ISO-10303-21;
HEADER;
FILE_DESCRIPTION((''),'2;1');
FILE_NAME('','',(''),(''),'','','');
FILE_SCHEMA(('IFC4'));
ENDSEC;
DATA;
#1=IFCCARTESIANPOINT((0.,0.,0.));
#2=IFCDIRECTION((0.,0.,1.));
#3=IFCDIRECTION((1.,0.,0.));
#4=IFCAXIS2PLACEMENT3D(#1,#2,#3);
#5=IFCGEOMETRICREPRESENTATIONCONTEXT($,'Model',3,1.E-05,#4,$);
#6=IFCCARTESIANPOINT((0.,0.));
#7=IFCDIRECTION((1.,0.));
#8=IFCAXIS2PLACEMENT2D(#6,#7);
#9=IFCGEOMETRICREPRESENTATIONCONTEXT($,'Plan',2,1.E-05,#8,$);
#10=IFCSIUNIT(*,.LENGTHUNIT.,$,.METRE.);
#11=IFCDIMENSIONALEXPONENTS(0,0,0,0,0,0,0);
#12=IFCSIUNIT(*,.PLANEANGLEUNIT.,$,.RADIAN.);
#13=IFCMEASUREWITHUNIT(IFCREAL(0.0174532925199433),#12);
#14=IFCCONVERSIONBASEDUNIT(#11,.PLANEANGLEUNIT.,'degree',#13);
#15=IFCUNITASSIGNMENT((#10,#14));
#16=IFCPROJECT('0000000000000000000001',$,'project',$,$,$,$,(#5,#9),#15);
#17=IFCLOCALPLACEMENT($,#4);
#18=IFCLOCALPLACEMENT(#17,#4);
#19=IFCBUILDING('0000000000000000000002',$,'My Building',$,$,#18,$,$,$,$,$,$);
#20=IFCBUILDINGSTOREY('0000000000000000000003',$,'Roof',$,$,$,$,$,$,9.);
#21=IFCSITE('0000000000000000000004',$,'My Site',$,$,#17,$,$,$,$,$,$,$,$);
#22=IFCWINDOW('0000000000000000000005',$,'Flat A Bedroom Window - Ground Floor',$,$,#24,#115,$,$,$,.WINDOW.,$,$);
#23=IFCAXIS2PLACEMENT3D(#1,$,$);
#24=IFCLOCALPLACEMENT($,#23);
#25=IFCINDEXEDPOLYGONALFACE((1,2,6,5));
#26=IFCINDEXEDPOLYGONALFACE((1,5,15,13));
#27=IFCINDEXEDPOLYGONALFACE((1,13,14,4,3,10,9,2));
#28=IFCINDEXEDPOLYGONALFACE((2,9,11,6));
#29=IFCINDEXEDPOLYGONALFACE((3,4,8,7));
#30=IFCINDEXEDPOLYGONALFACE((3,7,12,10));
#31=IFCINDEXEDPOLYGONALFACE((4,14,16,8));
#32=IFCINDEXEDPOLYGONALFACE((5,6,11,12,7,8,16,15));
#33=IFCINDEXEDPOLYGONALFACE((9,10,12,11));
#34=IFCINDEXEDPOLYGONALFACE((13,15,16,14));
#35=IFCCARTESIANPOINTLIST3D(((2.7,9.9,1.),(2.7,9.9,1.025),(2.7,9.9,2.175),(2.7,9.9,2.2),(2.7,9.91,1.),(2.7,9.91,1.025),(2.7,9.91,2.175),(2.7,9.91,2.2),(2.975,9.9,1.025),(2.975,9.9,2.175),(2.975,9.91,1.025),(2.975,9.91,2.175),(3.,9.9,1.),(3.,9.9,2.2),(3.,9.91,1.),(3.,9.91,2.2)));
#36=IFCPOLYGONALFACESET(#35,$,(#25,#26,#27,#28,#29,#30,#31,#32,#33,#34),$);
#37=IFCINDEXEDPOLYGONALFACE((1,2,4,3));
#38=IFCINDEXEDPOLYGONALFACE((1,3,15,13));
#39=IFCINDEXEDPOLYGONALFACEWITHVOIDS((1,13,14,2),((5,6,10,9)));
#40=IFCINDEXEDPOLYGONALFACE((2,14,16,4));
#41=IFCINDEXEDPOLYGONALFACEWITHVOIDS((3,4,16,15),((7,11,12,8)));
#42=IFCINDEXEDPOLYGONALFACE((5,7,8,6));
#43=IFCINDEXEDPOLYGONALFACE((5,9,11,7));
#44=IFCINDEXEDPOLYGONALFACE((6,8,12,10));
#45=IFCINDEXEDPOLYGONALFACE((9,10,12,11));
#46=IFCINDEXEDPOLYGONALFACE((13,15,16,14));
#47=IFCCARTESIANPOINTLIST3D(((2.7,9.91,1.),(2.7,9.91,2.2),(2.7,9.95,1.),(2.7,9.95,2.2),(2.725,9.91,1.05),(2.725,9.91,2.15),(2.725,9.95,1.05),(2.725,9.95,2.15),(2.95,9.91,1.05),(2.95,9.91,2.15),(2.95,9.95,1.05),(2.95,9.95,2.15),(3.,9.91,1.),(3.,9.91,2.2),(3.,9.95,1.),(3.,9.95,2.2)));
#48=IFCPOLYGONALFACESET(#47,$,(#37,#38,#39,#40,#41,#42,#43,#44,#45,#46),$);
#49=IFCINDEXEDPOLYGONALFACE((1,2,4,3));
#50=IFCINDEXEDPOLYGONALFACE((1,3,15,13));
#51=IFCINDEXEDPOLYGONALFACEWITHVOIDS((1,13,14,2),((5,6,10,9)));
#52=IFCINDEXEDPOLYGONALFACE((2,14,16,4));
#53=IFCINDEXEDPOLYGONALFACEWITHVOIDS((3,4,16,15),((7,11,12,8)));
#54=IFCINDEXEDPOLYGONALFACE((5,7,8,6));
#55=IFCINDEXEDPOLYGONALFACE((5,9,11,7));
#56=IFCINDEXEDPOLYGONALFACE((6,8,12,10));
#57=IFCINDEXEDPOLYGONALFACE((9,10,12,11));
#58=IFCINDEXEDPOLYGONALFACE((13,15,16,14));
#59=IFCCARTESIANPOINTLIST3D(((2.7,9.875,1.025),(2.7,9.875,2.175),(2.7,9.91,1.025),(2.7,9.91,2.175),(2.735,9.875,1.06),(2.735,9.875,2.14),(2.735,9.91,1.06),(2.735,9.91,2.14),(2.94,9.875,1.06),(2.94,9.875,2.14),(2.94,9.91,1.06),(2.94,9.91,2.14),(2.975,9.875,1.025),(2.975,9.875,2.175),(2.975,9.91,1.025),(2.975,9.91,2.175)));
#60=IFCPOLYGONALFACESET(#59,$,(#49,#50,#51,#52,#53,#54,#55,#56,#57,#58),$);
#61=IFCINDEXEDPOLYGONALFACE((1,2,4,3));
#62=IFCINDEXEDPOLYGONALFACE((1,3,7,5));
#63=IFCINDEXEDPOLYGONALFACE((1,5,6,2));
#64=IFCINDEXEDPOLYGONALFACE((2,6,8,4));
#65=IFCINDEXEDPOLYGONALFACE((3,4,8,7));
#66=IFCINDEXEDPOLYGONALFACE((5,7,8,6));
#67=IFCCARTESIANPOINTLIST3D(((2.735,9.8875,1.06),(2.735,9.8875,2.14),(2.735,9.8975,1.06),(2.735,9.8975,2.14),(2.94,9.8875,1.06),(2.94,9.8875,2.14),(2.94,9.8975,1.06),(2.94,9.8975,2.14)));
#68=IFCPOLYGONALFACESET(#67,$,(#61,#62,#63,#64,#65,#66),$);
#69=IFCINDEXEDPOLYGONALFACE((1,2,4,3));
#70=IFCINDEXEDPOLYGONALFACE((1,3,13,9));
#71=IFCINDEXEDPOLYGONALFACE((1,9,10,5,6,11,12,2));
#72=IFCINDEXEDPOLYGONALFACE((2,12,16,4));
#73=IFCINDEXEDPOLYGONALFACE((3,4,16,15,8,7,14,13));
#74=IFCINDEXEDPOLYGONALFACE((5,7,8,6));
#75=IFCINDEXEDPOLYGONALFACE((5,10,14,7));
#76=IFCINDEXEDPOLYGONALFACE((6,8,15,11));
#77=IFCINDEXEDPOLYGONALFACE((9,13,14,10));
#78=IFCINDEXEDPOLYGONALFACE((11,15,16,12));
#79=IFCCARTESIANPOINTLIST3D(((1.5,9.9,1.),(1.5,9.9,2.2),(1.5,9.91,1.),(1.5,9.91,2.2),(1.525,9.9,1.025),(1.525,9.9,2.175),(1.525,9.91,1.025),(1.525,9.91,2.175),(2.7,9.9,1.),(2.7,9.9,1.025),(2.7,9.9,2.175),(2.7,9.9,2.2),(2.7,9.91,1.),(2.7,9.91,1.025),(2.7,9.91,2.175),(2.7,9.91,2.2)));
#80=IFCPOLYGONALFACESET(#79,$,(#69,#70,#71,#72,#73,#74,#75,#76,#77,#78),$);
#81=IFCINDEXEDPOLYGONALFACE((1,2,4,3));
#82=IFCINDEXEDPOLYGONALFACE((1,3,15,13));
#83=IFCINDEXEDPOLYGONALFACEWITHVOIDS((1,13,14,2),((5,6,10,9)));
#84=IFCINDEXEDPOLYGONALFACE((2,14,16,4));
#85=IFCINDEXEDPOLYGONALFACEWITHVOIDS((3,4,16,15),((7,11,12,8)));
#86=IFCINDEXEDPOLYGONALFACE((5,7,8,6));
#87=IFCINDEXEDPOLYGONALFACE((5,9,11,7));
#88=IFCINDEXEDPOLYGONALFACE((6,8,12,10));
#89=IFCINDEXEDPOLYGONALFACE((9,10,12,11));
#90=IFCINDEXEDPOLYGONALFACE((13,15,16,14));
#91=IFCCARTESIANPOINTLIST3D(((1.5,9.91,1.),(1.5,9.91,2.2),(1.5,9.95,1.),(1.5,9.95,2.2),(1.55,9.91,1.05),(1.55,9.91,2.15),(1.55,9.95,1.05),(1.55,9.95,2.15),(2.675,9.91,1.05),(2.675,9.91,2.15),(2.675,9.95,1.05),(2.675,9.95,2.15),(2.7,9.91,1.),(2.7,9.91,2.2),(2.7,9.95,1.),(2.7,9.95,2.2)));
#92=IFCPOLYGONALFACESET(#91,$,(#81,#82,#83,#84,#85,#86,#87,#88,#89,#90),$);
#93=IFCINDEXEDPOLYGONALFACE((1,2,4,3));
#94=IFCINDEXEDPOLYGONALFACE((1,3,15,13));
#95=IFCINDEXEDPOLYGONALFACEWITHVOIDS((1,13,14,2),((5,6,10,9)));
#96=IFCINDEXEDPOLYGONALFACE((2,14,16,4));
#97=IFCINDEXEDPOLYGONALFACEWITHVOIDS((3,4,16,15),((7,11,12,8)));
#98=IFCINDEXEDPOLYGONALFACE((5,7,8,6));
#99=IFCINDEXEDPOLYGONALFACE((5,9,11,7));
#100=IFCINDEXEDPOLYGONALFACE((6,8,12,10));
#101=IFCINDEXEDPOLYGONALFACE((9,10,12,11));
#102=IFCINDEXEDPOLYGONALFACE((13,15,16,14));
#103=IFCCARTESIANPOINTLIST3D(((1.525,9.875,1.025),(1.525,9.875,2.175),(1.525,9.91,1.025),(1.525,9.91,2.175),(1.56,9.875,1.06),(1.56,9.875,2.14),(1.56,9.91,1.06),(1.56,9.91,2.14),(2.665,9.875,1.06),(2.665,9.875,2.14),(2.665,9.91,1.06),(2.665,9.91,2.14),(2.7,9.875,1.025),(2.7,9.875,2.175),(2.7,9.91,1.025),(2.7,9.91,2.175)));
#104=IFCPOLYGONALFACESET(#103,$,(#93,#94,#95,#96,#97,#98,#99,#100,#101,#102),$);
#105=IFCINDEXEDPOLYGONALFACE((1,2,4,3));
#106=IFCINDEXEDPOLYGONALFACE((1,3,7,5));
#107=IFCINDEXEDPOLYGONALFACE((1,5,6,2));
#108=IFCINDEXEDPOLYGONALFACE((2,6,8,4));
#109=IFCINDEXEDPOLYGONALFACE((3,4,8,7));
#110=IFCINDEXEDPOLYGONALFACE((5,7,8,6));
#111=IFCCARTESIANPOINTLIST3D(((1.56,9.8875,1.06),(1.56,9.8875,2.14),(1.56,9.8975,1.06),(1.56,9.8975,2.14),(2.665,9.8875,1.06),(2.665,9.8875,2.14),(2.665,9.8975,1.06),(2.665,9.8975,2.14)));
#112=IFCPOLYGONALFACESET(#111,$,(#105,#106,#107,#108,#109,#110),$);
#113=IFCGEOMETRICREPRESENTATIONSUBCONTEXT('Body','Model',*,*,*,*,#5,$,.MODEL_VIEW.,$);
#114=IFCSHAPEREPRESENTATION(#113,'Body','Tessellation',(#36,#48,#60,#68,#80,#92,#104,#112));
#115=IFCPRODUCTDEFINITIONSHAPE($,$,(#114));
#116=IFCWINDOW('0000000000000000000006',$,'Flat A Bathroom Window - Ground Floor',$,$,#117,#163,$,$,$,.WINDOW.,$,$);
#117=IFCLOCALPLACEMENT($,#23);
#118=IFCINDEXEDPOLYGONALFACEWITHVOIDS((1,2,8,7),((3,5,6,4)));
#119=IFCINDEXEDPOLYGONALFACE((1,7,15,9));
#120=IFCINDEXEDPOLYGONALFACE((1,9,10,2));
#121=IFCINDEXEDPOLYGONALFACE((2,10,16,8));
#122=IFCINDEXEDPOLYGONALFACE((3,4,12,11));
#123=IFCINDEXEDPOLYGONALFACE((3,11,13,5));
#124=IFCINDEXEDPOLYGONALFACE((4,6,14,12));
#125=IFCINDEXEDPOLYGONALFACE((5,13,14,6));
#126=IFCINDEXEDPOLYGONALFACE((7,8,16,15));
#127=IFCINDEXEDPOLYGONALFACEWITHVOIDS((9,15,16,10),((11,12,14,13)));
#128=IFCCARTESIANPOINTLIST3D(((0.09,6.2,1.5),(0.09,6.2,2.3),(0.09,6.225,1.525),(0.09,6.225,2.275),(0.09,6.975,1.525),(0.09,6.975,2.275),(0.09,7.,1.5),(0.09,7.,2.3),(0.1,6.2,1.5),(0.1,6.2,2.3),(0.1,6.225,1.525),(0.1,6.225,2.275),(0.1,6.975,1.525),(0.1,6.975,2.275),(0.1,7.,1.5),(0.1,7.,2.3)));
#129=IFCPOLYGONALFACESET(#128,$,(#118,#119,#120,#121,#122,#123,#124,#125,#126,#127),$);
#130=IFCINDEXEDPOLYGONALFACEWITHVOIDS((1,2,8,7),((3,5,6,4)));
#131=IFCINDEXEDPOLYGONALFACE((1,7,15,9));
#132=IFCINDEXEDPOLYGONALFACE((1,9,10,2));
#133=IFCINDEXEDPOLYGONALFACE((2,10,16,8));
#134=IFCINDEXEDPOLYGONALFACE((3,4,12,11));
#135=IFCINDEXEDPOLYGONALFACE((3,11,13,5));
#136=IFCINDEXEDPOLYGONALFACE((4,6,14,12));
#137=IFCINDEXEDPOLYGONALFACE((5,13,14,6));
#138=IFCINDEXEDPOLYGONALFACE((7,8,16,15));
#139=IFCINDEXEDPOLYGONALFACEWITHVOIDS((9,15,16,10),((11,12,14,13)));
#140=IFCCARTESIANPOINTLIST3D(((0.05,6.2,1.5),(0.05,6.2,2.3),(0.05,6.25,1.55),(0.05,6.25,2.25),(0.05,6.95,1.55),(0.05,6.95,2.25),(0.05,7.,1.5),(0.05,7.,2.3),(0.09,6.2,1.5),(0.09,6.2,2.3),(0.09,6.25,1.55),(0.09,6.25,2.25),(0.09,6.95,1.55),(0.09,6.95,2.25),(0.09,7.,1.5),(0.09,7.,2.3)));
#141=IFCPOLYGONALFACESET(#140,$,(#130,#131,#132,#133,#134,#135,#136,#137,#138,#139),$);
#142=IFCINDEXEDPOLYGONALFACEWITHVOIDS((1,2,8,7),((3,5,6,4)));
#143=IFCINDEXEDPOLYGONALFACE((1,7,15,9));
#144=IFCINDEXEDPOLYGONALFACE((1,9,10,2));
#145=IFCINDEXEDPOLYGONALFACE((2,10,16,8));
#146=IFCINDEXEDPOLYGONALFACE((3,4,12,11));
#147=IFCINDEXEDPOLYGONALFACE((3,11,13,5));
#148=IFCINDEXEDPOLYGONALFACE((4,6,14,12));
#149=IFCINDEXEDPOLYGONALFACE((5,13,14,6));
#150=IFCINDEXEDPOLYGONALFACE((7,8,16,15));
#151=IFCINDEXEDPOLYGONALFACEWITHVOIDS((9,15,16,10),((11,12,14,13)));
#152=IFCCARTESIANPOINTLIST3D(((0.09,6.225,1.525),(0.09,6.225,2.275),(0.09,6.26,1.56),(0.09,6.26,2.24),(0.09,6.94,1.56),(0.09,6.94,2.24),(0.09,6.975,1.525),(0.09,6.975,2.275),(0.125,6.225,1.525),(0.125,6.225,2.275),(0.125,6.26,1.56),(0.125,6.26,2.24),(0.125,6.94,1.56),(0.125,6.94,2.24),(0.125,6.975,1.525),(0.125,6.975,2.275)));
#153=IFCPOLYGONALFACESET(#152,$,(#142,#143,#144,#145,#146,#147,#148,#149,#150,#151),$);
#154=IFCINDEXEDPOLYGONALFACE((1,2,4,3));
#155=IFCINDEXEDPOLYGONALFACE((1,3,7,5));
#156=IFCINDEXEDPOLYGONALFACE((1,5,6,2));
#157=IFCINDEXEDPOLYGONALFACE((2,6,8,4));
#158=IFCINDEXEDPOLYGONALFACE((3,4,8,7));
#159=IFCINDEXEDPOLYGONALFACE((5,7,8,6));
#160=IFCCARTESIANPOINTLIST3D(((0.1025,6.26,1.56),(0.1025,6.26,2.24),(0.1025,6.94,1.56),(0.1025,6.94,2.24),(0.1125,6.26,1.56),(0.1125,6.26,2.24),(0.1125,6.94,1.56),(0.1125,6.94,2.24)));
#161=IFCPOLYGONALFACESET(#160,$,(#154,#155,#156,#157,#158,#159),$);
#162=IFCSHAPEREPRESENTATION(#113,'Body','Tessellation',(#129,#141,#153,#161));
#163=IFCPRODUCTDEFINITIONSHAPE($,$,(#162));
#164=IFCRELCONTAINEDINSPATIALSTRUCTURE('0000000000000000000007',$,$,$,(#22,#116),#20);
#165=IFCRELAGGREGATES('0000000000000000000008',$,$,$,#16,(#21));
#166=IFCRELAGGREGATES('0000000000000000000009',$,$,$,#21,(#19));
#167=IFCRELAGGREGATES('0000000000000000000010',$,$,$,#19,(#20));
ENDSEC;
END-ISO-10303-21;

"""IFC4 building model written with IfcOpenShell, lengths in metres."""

from ifc_helpers import new_model, entity, si_unit, converted_unit, frame, origin_with_axes, origin_2d_with_axis, place, context, subcontext, project, spatial, line, indexed_curve, outline, extrude, element, save


model = new_model("IFC4")

# Units and contexts
model_context = context("Model", 3, precision=1e-05, world=origin_with_axes())
plan_context = context("Plan", 2, precision=1e-05, world=origin_2d_with_axis())
body_context = subcontext(model_context, "Body", "Model", "MODEL_VIEW")
ifc_project = project(units=[si_unit("LENGTHUNIT", "METRE"), converted_unit("PLANEANGLEUNIT", "degree", entity("IfcReal", 0.0174532925199433), si_unit("PLANEANGLEUNIT", "RADIAN"), dimensions=[0, 0, 0, 0, 0, 0, 0])], contexts=[model_context, plan_context])

# Site, building, storey
site_placement = place(None, origin_with_axes())
site = spatial("IfcSite", under=ifc_project, at=site_placement, Name="My Site")
building_placement = place(site_placement, origin_with_axes())
building = spatial("IfcBuilding", under=site, at=building_placement, Name="My Building")
storey = spatial("IfcBuildingStorey", under=building, Name="Roof", Elevation=9.0)

# Windows
window_1_placement = place(None, frame((3.0, 10.0, 1.0), z_axis=(0.0, 0.0, 1.0), x_axis=(-1.0, 0.0, 0.0)))
element("IfcWindow", 1, at=window_1_placement, inside=storey, Name="Flat A Bedroom Window - Ground Floor", PredefinedType="WINDOW", context=body_context, shape_type="SweptSolid", body=[
    extrude(outline(indexed_curve([(0.3, 0.0), (0.0, 0.0), (0.0, 1.2), (0.3, 1.2), (0.3, 1.175), (0.025, 1.175), (0.025, 0.025), (0.3, 0.025)], segments=[line(1, 2, 3, 4, 5, 6, 7, 8, 1)])), frame((0.0, 0.09, 0.0), z_axis=(0.0, -1.0, 0.0), x_axis=(1.0, 0.0, 0.0)), (0.0, 0.0, -1.0), 0.01),
    extrude(outline(indexed_curve([(0.0, 0.0), (0.3, 0.0), (0.3, 1.2), (0.0, 1.2)], segments=[line(1, 2, 3, 4, 1)]), holes=[indexed_curve([(0.05, 0.05), (0.275, 0.05), (0.275, 1.15), (0.05, 1.15)], segments=[line(1, 2, 3, 4, 1)])]), frame((0.0, 0.05, 0.0), z_axis=(0.0, -1.0, 0.0), x_axis=(1.0, 0.0, 0.0)), (0.0, 0.0, -1.0), 0.04),
    extrude(outline(indexed_curve([(0.0, 0.0), (0.275, 0.0), (0.275, 1.15), (0.0, 1.15)], segments=[line(1, 2, 3, 4, 1)]), holes=[indexed_curve([(0.035, 0.035), (0.24, 0.035), (0.24, 1.115), (0.035, 1.115)], segments=[line(1, 2, 3, 4, 1)])]), frame((0.025, 0.09, 0.025), z_axis=(0.0, -1.0, 0.0), x_axis=(1.0, 0.0, 0.0)), (0.0, 0.0, -1.0), 0.035),
    extrude(outline(indexed_curve([(0.035, 0.035), (0.24, 0.035), (0.24, 1.115), (0.035, 1.115)], segments=[line(1, 2, 3, 4, 1)])), frame((0.025, 0.1025, 0.025), z_axis=(0.0, -1.0, 0.0), x_axis=(1.0, 0.0, 0.0)), (0.0, 0.0, -1.0), 0.01),
    extrude(outline(indexed_curve([(0.0, 1.2), (1.2, 1.2), (1.2, 0.0), (0.0, 0.0), (0.0, 0.025), (1.175, 0.025), (1.175, 1.175), (0.0, 1.175)], segments=[line(1, 2, 3, 4, 5, 6, 7, 8, 1)])), frame((0.3, 0.09, 0.0), z_axis=(0.0, -1.0, 0.0), x_axis=(1.0, 0.0, 0.0)), (0.0, 0.0, -1.0), 0.01),
    extrude(outline(indexed_curve([(0.0, 0.0), (1.2, 0.0), (1.2, 1.2), (0.0, 1.2)], segments=[line(1, 2, 3, 4, 1)]), holes=[indexed_curve([(0.025, 0.05), (1.15, 0.05), (1.15, 1.15), (0.025, 1.15)], segments=[line(1, 2, 3, 4, 1)])]), frame((0.3, 0.05, 0.0), z_axis=(0.0, -1.0, 0.0), x_axis=(1.0, 0.0, 0.0)), (0.0, 0.0, -1.0), 0.04),
    extrude(outline(indexed_curve([(0.0, 0.0), (1.175, 0.0), (1.175, 1.15), (0.0, 1.15)], segments=[line(1, 2, 3, 4, 1)]), holes=[indexed_curve([(0.035, 0.035), (1.14, 0.035), (1.14, 1.115), (0.035, 1.115)], segments=[line(1, 2, 3, 4, 1)])]), frame((0.3, 0.09, 0.025), z_axis=(0.0, -1.0, 0.0), x_axis=(1.0, 0.0, 0.0)), (0.0, 0.0, -1.0), 0.035),
    extrude(outline(indexed_curve([(0.035, 0.035), (1.14, 0.035), (1.14, 1.115), (0.035, 1.115)], segments=[line(1, 2, 3, 4, 1)])), frame((0.3, 0.1025, 0.025), z_axis=(0.0, -1.0, 0.0), x_axis=(1.0, 0.0, 0.0)), (0.0, 0.0, -1.0), 0.01),
])
window_2_placement = place(None, frame((0.0, 7.0, 1.5), z_axis=(0.0, 0.0, 1.0), x_axis=(0.0, -1.0, 0.0)))
element("IfcWindow", 2, at=window_2_placement, inside=storey, Name="Flat A Bathroom Window - Ground Floor", PredefinedType="WINDOW", context=body_context, shape_type="SweptSolid", body=[
    extrude(outline(indexed_curve([(0.0, 0.0), (0.8, 0.0), (0.8, 0.8), (0.0, 0.8)], segments=[line(1, 2, 3, 4, 1)]), holes=[indexed_curve([(0.025, 0.025), (0.775, 0.025), (0.775, 0.775), (0.025, 0.775)], segments=[line(1, 2, 3, 4, 1)])]), frame((0.0, 0.09, 0.0), z_axis=(0.0, -1.0, 0.0), x_axis=(1.0, 0.0, 0.0)), (0.0, 0.0, -1.0), 0.01),
    extrude(outline(indexed_curve([(0.0, 0.0), (0.8, 0.0), (0.8, 0.8), (0.0, 0.8)], segments=[line(1, 2, 3, 4, 1)]), holes=[indexed_curve([(0.05, 0.05), (0.75, 0.05), (0.75, 0.75), (0.05, 0.75)], segments=[line(1, 2, 3, 4, 1)])]), frame((0.0, 0.05, 0.0), z_axis=(0.0, -1.0, 0.0), x_axis=(1.0, 0.0, 0.0)), (0.0, 0.0, -1.0), 0.04),
    extrude(outline(indexed_curve([(0.0, 0.0), (0.75, 0.0), (0.75, 0.75), (0.0, 0.75)], segments=[line(1, 2, 3, 4, 1)]), holes=[indexed_curve([(0.035, 0.035), (0.715, 0.035), (0.715, 0.715), (0.035, 0.715)], segments=[line(1, 2, 3, 4, 1)])]), frame((0.025, 0.09, 0.025), z_axis=(0.0, -1.0, 0.0), x_axis=(1.0, 0.0, 0.0)), (0.0, 0.0, -1.0), 0.035),
    extrude(outline(indexed_curve([(0.035, 0.035), (0.715, 0.035), (0.715, 0.715), (0.035, 0.715)], segments=[line(1, 2, 3, 4, 1)])), frame((0.025, 0.1025, 0.025), z_axis=(0.0, -1.0, 0.0), x_axis=(1.0, 0.0, 0.0)), (0.0, 0.0, -1.0), 0.01),
])

save(model, "model.ifc")
